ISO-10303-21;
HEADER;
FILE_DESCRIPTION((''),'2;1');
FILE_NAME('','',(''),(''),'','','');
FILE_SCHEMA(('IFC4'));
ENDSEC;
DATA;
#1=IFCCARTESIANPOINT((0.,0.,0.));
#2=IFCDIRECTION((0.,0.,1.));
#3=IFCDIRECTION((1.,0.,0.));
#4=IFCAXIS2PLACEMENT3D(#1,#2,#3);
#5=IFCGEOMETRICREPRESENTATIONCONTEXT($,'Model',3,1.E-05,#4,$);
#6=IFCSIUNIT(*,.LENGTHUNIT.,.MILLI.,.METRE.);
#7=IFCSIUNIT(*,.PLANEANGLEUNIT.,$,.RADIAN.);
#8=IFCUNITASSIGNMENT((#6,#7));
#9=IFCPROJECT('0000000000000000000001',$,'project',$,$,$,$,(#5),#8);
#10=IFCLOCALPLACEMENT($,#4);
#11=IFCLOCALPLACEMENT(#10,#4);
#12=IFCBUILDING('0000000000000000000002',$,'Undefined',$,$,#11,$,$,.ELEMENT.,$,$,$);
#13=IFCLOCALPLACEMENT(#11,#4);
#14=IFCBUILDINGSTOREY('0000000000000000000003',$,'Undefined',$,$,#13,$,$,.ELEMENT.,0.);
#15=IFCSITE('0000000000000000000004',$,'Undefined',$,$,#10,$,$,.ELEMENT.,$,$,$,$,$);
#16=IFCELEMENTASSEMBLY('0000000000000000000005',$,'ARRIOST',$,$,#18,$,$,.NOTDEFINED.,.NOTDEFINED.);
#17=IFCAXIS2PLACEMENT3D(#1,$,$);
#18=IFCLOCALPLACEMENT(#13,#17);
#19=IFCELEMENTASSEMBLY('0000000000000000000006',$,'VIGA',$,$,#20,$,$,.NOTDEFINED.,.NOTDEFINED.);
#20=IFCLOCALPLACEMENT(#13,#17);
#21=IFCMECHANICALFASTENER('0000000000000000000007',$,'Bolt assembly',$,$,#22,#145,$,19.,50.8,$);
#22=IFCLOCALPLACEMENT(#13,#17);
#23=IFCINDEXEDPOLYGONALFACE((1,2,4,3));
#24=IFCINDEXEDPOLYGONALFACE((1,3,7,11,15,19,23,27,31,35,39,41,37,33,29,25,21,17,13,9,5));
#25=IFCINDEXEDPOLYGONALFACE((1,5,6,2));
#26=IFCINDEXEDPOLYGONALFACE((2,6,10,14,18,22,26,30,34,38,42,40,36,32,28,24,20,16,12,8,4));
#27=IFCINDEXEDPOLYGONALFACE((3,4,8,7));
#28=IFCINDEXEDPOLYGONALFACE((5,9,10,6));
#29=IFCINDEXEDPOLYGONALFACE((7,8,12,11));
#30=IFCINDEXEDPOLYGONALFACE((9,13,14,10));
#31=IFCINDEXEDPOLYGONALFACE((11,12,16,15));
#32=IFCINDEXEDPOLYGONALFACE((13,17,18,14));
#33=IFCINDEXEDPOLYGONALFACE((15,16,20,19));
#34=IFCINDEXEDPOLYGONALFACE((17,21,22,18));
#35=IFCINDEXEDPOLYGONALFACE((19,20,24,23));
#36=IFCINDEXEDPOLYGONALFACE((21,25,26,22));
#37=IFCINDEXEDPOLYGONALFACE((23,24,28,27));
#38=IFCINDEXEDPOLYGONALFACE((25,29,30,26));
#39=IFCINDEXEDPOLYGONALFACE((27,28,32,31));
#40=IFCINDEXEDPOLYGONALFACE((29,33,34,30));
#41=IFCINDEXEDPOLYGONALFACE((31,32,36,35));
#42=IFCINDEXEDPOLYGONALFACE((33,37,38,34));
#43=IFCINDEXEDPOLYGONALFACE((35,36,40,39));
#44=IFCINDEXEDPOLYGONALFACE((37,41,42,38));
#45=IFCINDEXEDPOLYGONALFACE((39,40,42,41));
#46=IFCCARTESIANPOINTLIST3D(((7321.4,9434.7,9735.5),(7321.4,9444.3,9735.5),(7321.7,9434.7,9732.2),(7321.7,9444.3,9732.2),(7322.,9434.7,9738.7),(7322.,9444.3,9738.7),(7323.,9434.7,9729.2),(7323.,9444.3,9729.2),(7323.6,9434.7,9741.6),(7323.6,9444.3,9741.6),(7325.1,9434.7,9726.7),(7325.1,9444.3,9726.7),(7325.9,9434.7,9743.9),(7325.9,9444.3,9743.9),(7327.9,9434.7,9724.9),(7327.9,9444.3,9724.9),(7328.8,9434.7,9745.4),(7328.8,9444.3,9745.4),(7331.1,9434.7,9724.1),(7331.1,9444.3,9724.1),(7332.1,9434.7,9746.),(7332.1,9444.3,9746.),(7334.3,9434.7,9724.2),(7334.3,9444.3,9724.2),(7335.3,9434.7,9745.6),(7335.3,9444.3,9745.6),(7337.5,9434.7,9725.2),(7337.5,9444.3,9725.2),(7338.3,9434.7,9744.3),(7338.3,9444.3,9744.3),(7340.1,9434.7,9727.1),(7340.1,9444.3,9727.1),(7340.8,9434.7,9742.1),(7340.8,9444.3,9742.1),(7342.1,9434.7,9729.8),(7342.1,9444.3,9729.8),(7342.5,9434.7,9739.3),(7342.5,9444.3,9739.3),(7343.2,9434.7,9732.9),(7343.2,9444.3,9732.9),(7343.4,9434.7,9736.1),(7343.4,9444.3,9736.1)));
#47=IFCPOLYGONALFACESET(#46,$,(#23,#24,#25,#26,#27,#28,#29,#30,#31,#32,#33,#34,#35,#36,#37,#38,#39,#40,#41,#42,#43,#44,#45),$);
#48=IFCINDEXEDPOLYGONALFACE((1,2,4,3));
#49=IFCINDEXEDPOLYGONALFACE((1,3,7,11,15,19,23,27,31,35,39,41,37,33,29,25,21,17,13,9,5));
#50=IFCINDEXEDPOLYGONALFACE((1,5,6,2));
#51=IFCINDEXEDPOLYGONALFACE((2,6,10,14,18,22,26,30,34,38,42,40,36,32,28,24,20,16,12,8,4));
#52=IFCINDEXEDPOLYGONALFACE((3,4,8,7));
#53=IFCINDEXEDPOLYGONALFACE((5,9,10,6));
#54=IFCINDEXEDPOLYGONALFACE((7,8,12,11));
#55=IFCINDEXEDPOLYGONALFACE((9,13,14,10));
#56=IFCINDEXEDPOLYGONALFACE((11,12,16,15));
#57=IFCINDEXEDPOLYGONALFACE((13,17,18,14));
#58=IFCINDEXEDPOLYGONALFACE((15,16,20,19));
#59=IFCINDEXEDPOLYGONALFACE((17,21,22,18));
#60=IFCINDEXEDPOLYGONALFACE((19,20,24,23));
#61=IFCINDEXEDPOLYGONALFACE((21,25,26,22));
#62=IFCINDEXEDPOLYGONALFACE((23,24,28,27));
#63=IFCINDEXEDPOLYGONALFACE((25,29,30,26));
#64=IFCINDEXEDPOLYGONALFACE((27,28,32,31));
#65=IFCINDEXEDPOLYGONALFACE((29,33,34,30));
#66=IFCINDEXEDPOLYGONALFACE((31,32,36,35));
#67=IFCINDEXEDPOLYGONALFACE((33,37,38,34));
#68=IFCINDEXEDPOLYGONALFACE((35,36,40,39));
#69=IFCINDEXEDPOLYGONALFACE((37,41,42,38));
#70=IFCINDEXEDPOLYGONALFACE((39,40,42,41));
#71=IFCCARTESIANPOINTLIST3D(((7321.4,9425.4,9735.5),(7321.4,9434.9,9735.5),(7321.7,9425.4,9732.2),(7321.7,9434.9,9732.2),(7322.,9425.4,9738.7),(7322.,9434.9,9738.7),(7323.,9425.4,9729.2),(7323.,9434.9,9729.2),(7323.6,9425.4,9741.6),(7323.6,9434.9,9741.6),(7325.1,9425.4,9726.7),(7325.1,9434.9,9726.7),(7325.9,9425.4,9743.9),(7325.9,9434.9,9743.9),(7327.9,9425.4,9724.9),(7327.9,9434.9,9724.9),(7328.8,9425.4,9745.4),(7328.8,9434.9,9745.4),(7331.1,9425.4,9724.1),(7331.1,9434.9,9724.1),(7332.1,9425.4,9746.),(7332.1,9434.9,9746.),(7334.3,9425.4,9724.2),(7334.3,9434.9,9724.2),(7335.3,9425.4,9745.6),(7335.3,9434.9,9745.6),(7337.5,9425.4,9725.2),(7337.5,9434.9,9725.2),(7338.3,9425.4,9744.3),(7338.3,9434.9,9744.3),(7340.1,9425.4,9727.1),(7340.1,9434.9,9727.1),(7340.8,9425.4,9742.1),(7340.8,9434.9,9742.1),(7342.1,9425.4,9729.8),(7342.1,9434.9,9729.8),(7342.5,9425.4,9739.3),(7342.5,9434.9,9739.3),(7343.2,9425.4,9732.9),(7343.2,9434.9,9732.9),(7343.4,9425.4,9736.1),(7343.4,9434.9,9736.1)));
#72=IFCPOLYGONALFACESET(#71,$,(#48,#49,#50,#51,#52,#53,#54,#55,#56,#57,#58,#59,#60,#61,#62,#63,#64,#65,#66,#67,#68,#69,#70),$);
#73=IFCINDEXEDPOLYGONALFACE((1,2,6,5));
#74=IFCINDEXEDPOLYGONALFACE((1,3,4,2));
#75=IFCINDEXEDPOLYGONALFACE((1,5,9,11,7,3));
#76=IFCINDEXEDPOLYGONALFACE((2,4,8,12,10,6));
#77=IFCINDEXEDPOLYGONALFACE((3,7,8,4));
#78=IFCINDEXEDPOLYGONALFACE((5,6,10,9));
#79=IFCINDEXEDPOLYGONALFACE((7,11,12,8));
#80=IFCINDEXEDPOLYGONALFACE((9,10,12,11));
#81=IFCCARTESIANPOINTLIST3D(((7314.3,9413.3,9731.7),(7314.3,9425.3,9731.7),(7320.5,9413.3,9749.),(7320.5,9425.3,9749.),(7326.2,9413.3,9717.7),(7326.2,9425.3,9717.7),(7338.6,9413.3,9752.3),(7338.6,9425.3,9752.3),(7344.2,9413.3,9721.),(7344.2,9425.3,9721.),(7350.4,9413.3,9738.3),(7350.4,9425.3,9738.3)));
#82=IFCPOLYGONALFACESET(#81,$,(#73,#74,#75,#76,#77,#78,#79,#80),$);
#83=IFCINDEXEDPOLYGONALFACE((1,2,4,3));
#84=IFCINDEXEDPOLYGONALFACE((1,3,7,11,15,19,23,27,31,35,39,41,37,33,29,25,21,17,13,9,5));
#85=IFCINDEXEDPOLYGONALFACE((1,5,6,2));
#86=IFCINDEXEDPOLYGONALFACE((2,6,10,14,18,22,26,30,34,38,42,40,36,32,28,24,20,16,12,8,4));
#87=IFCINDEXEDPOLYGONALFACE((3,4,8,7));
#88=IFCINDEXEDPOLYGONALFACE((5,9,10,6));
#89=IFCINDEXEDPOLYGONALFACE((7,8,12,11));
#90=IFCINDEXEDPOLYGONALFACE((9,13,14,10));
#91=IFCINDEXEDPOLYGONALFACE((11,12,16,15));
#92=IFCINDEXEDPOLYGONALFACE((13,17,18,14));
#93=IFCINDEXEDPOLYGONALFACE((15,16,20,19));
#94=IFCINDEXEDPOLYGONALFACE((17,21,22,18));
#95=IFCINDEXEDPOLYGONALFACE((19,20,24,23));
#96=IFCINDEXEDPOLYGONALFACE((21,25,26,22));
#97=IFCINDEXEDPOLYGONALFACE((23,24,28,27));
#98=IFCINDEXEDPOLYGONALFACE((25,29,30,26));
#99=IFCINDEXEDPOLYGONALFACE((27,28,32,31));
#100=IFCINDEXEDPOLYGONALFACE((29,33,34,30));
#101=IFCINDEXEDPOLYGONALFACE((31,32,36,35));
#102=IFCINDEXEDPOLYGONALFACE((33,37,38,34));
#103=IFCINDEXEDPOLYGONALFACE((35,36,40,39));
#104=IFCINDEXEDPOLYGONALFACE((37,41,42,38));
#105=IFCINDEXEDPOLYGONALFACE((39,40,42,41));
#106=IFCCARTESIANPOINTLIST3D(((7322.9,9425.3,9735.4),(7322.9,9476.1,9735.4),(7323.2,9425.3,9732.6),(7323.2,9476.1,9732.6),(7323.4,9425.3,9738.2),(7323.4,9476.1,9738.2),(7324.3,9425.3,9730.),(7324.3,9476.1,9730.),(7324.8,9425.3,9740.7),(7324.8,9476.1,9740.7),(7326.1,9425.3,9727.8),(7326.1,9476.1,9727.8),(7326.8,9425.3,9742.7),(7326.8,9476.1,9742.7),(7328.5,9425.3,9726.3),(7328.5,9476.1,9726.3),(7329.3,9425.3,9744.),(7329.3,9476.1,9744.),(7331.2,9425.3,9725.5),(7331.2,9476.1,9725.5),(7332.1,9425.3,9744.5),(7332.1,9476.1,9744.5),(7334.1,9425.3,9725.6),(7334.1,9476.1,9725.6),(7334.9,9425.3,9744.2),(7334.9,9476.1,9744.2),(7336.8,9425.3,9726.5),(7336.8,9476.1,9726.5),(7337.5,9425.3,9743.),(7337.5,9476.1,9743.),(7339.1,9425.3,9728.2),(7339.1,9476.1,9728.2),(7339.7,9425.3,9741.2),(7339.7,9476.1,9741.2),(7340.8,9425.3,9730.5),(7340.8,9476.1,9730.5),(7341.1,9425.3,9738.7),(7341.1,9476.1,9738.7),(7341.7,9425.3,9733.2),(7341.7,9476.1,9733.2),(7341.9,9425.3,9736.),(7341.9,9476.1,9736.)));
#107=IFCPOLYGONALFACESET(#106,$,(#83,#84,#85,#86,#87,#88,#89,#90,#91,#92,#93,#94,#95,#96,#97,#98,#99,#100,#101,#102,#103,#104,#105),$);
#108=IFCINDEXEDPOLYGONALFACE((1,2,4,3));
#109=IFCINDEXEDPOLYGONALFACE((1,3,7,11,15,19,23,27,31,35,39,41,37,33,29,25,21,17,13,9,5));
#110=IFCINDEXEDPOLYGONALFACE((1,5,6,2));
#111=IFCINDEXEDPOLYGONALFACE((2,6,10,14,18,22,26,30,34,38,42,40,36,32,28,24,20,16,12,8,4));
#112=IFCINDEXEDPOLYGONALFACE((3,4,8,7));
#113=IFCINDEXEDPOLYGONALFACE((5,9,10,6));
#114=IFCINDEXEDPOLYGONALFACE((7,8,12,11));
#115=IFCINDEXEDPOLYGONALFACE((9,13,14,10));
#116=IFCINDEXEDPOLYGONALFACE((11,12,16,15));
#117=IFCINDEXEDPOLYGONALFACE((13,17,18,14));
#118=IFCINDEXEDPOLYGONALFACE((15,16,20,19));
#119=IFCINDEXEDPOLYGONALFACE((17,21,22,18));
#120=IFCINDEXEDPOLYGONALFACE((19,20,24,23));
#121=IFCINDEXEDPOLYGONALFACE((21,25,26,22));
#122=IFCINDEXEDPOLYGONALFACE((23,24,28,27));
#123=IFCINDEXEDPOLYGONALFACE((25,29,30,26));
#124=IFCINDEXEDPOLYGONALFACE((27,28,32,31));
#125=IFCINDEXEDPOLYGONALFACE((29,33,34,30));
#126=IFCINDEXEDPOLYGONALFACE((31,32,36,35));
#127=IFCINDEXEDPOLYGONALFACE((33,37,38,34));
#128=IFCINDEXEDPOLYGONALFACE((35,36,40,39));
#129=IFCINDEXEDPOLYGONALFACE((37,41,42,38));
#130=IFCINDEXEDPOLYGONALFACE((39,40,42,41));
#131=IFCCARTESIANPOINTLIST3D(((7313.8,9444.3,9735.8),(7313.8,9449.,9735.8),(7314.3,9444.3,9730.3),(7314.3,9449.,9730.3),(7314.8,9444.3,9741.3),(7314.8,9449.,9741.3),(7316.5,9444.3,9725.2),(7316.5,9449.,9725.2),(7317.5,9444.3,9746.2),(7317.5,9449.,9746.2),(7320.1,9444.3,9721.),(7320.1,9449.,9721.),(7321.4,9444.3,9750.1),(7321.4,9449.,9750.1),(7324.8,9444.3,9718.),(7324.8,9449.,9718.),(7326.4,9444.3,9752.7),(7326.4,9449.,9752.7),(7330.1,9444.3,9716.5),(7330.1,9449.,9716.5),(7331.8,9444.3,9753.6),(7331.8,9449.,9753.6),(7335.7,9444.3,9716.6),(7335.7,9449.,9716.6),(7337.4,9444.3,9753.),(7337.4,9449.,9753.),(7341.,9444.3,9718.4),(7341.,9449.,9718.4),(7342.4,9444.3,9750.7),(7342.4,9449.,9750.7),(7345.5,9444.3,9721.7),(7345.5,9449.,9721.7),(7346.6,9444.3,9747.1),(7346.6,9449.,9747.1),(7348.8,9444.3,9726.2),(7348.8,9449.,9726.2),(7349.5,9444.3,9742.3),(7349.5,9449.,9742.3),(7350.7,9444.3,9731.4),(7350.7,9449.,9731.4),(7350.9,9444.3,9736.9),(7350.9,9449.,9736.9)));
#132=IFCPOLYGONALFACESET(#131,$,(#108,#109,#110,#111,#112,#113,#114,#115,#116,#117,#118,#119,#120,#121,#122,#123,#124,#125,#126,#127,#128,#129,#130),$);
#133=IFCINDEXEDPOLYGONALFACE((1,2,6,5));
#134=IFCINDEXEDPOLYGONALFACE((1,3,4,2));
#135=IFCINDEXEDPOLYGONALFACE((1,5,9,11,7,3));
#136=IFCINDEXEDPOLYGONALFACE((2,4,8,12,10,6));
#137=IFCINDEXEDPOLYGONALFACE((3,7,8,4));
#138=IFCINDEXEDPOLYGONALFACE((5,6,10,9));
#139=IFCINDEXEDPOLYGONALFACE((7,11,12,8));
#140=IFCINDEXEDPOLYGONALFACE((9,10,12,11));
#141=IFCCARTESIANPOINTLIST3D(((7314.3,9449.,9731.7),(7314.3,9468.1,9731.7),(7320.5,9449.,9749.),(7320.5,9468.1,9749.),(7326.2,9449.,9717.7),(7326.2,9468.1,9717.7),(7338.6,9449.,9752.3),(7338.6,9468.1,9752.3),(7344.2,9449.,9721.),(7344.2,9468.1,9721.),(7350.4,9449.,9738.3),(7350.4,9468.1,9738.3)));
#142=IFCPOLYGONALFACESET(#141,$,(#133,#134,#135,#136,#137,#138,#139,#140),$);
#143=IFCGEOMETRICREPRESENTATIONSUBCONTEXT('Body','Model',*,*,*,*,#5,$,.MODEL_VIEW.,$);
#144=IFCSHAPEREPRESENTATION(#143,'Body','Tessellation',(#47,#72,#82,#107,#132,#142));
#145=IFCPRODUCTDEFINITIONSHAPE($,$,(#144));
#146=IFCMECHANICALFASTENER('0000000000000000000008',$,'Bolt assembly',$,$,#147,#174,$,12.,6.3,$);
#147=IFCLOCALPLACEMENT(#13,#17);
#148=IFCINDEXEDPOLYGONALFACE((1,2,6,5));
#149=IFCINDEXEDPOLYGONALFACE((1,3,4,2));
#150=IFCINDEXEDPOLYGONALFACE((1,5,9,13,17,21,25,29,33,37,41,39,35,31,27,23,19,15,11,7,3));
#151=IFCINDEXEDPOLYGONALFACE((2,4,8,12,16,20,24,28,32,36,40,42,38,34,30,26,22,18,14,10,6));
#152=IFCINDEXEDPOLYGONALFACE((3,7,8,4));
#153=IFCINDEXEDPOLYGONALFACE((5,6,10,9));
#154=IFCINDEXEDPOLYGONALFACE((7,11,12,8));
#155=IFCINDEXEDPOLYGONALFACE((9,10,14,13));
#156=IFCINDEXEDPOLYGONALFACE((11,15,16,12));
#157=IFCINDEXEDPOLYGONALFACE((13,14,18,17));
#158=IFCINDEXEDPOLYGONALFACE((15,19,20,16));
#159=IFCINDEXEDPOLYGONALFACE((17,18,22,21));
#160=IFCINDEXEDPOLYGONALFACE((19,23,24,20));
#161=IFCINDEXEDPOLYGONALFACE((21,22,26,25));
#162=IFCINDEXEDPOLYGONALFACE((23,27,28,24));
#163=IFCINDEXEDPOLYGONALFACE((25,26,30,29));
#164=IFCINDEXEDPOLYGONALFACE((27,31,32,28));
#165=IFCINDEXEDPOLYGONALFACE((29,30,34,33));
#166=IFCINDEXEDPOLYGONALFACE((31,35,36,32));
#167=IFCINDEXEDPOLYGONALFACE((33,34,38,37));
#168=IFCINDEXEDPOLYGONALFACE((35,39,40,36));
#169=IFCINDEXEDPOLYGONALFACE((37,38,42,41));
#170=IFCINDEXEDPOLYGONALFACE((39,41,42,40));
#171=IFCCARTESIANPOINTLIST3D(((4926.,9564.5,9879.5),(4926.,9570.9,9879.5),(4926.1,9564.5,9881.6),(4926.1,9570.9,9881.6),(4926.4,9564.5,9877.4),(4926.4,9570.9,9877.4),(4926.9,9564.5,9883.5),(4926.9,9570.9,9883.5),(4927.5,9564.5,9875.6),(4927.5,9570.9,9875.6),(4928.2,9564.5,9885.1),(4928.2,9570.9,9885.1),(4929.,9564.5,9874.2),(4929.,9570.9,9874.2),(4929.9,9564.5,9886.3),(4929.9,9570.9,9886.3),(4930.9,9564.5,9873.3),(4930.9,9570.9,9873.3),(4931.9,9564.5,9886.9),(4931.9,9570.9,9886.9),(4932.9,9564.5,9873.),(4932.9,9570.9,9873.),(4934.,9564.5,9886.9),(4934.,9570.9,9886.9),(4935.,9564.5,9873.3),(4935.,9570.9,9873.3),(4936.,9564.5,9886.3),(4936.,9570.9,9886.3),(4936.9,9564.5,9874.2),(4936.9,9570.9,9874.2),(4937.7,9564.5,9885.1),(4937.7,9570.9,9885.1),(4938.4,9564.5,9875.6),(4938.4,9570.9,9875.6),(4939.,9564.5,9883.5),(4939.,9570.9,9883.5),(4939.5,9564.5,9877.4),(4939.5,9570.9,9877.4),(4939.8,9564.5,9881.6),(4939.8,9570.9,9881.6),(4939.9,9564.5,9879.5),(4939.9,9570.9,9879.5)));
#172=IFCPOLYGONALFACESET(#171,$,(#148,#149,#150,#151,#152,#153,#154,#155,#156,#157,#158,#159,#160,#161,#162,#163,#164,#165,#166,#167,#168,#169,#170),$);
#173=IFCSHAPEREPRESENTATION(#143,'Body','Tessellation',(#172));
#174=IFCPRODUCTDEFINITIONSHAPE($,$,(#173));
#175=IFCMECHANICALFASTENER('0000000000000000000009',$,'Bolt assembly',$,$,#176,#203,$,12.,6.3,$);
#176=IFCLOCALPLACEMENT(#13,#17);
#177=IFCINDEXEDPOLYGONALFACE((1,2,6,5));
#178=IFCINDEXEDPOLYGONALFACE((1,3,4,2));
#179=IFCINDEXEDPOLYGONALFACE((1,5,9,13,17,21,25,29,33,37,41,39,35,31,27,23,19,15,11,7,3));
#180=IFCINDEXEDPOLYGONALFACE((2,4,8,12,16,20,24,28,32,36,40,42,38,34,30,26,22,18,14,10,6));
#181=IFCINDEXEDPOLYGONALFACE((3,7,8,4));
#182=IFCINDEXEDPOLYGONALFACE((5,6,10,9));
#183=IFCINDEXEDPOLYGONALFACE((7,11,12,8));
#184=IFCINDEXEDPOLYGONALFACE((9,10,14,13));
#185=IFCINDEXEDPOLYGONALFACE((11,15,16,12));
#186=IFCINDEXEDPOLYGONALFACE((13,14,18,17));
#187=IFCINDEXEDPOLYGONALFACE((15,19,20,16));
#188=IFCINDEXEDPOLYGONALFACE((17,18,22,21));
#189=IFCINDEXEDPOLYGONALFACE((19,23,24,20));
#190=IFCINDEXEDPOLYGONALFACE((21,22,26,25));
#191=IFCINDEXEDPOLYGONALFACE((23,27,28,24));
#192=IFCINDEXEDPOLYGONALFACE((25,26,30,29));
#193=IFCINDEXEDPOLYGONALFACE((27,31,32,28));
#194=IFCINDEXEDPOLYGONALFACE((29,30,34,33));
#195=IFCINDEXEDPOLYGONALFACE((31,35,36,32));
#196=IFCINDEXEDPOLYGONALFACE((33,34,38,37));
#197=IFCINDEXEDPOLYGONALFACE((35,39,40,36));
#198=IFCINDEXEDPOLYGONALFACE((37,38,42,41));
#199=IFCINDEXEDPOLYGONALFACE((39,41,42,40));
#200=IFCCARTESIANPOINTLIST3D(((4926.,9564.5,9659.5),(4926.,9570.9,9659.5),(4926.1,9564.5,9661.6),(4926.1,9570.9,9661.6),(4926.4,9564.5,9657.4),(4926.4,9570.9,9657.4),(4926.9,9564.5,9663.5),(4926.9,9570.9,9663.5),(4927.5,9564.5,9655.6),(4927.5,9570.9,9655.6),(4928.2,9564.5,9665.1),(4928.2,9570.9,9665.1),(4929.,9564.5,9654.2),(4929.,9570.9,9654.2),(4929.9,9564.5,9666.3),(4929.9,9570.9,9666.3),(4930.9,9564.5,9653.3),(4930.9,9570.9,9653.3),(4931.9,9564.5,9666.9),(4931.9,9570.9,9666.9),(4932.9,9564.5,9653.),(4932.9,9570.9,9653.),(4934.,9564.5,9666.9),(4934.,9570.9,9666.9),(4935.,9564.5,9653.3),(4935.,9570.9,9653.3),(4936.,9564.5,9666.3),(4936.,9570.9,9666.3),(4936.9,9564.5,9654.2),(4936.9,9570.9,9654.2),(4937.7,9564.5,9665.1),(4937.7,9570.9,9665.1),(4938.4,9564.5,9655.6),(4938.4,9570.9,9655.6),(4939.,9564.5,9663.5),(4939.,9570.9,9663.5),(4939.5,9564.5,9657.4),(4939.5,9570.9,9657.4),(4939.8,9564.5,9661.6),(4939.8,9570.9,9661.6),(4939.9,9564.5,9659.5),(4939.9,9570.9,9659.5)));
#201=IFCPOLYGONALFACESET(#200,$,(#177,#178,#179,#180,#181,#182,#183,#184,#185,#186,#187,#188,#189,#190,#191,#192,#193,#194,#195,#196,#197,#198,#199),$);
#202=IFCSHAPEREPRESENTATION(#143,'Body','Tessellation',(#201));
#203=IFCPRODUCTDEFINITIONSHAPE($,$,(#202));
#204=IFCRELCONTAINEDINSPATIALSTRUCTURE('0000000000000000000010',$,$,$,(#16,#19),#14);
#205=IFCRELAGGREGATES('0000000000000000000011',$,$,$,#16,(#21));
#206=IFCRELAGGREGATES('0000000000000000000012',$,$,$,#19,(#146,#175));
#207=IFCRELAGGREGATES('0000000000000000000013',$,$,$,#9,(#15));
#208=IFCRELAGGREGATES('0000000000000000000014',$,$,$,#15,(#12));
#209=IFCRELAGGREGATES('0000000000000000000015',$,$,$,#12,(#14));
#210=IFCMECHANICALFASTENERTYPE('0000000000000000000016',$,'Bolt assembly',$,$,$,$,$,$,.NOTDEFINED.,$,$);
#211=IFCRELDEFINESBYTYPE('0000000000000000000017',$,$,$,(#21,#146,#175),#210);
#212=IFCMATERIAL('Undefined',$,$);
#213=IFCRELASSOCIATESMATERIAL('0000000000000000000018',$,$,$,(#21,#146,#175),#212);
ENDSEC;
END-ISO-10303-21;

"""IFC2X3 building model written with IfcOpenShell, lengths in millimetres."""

from ifc_helpers import new_model, si_unit, frame, origin_with_axes, origin_2d_with_axis, place, context, subcontext, project, spatial, polyline, circle, outline, extrude, source, transform, mapped, material, type_object, element, aggregate, save


model = new_model("IFC2X3")

# Units and contexts
model_context = context("Model", 3, precision=1e-05, world=origin_with_axes())
body_context = subcontext(model_context, "Body", "Model", "MODEL_VIEW")
ifc_project = project(units=[si_unit("LENGTHUNIT", "METRE", prefix="MILLI"), si_unit("PLANEANGLEUNIT", "RADIAN")], contexts=[model_context])

# Site, building, storey
site_placement = place(None, origin_with_axes())
site = spatial("IfcSite", under=ifc_project, at=site_placement, Name="Undefined", CompositionType="ELEMENT")
building_placement = place(site_placement, origin_with_axes())
building = spatial("IfcBuilding", under=site, at=building_placement, Name="Undefined", CompositionType="ELEMENT")
storey_placement = place(building_placement, origin_with_axes())
storey = spatial("IfcBuildingStorey", under=building, at=storey_placement, Name="Undefined", CompositionType="ELEMENT", Elevation=0.0)

# Element assembly
assembly_1_placement = place(storey_placement, origin_with_axes())
assembly_1 = element("IfcElementAssembly", 1, at=assembly_1_placement, inside=storey, Name="ARRIOST", AssemblyPlace="NOTDEFINED", PredefinedType="NOTDEFINED")

# Element assembly
assembly_2_placement = place(storey_placement, origin_with_axes())
assembly_2 = element("IfcElementAssembly", 2, at=assembly_2_placement, inside=storey, Name="VIGA", AssemblyPlace="NOTDEFINED", PredefinedType="NOTDEFINED")

# Mechanical fastener
ifc_material_1 = material(Name="Undefined")
mechanical_fastener_type = type_object("IfcMechanicalFastenerType", Name="Bolt assembly")
shared_shape_1 = source(origin_with_axes(), body_context, "Body", "SweptSolid", [
    extrude(circle(Radius=11.0, at=origin_2d_with_axis()), frame((0.0, 4.6, 0.0), z_axis=(0.0, 1.0, 0.0), x_axis=(1.0, 0.0, 0.0)), (0.0, 0.0, 1.0), 9.6),
    extrude(circle(Radius=11.0, at=origin_2d_with_axis()), frame((0.0, -4.6, 0.0), z_axis=(0.0, 1.0, 0.0), x_axis=(1.0, 0.0, 0.0)), (0.0, 0.0, 1.0), 9.5),
    extrude(outline(polyline([(15.9, -9.2), (15.9, 9.2), (0.0, 18.3), (-15.9, 9.2), (-15.9, -9.2), (0.0, -18.3), (15.9, -9.2)])), frame((0.0, -16.7, 0.0), z_axis=(0.0, 1.0, 0.0), x_axis=(1.0, 0.0, 0.0)), (0.0, 0.0, 1.0), 11.9),
    extrude(circle(Radius=9.5, at=origin_2d_with_axis()), frame((0.0, -4.7, 0.0), z_axis=(0.0, 1.0, 0.0), x_axis=(1.0, 0.0, 0.0)), (0.0, 0.0, 1.0), 50.8),
    extrude(circle(Radius=18.7, at=origin_2d_with_axis()), frame((0.0, 14.2, 0.0), z_axis=(0.0, 1.0, 0.0), x_axis=(1.0, 0.0, 0.0)), (0.0, 0.0, 1.0), 4.8),
    extrude(outline(polyline([(15.9, -9.2), (15.9, 9.2), (0.0, 18.3), (-15.9, 9.2), (-15.9, -9.2), (0.0, -18.3), (15.9, -9.2)])), frame((0.0, 19.0, 0.0), z_axis=(0.0, 1.0, 0.0), x_axis=(1.0, 0.0, 0.0)), (0.0, 0.0, 1.0), 19.1),
])
mechanical_fastener_1_placement = place(assembly_1_placement, frame((7332.4, 9430.0, 9735.0), z_axis=(-0.337824, 0.0, -0.941209), x_axis=(-0.941209, 0.0, 0.337824)))
mechanical_fastener_1 = element("IfcMechanicalFastener", 3, at=mechanical_fastener_1_placement, type_object=mechanical_fastener_type, material=ifc_material_1, Name="Bolt assembly", NominalDiameter=19.0, NominalLength=50.8, context=body_context, shape_type="MappedRepresentation", body=[
    mapped(shared_shape_1, transform((0.0, 0.0, 0.0))),
])
aggregate(assembly_1, [mechanical_fastener_1])

# Mechanical fasteners
shared_shape_2 = source(origin_with_axes(), body_context, "Body", "SweptSolid", [
    extrude(circle(Radius=7.0, at=origin_2d_with_axis()), frame((0.0, -6.4, 0.0), z_axis=(0.0, 1.0, 0.0), x_axis=(1.0, 0.0, 0.0)), (0.0, 0.0, 1.0), 6.5),
])
mechanical_fastener_2_placement = place(assembly_2_placement, frame((4932.9, 9570.8, 9880.0), z_axis=(1.0, 0.0, 0.0), x_axis=(0.0, 0.0, -1.0)))
mechanical_fastener_2 = element("IfcMechanicalFastener", 4, at=mechanical_fastener_2_placement, type_object=mechanical_fastener_type, material=ifc_material_1, Name="Bolt assembly", NominalDiameter=12.0, NominalLength=6.3, context=body_context, shape_type="MappedRepresentation", body=[
    mapped(shared_shape_2, transform((0.0, 0.0, 0.0))),
])
mechanical_fastener_3_placement = place(assembly_2_placement, frame((4932.9, 9570.8, 9660.0), z_axis=(1.0, 0.0, 0.0), x_axis=(0.0, 0.0, -1.0)))
mechanical_fastener_3 = element("IfcMechanicalFastener", 5, at=mechanical_fastener_3_placement, type_object=mechanical_fastener_type, material=ifc_material_1, Name="Bolt assembly", NominalDiameter=12.0, NominalLength=6.3, context=body_context, shape_type="MappedRepresentation", body=[
    mapped(shared_shape_2, transform((0.0, 0.0, 0.0))),
])
aggregate(assembly_2, [mechanical_fastener_2, mechanical_fastener_3])

save(model, "model.ifc")
